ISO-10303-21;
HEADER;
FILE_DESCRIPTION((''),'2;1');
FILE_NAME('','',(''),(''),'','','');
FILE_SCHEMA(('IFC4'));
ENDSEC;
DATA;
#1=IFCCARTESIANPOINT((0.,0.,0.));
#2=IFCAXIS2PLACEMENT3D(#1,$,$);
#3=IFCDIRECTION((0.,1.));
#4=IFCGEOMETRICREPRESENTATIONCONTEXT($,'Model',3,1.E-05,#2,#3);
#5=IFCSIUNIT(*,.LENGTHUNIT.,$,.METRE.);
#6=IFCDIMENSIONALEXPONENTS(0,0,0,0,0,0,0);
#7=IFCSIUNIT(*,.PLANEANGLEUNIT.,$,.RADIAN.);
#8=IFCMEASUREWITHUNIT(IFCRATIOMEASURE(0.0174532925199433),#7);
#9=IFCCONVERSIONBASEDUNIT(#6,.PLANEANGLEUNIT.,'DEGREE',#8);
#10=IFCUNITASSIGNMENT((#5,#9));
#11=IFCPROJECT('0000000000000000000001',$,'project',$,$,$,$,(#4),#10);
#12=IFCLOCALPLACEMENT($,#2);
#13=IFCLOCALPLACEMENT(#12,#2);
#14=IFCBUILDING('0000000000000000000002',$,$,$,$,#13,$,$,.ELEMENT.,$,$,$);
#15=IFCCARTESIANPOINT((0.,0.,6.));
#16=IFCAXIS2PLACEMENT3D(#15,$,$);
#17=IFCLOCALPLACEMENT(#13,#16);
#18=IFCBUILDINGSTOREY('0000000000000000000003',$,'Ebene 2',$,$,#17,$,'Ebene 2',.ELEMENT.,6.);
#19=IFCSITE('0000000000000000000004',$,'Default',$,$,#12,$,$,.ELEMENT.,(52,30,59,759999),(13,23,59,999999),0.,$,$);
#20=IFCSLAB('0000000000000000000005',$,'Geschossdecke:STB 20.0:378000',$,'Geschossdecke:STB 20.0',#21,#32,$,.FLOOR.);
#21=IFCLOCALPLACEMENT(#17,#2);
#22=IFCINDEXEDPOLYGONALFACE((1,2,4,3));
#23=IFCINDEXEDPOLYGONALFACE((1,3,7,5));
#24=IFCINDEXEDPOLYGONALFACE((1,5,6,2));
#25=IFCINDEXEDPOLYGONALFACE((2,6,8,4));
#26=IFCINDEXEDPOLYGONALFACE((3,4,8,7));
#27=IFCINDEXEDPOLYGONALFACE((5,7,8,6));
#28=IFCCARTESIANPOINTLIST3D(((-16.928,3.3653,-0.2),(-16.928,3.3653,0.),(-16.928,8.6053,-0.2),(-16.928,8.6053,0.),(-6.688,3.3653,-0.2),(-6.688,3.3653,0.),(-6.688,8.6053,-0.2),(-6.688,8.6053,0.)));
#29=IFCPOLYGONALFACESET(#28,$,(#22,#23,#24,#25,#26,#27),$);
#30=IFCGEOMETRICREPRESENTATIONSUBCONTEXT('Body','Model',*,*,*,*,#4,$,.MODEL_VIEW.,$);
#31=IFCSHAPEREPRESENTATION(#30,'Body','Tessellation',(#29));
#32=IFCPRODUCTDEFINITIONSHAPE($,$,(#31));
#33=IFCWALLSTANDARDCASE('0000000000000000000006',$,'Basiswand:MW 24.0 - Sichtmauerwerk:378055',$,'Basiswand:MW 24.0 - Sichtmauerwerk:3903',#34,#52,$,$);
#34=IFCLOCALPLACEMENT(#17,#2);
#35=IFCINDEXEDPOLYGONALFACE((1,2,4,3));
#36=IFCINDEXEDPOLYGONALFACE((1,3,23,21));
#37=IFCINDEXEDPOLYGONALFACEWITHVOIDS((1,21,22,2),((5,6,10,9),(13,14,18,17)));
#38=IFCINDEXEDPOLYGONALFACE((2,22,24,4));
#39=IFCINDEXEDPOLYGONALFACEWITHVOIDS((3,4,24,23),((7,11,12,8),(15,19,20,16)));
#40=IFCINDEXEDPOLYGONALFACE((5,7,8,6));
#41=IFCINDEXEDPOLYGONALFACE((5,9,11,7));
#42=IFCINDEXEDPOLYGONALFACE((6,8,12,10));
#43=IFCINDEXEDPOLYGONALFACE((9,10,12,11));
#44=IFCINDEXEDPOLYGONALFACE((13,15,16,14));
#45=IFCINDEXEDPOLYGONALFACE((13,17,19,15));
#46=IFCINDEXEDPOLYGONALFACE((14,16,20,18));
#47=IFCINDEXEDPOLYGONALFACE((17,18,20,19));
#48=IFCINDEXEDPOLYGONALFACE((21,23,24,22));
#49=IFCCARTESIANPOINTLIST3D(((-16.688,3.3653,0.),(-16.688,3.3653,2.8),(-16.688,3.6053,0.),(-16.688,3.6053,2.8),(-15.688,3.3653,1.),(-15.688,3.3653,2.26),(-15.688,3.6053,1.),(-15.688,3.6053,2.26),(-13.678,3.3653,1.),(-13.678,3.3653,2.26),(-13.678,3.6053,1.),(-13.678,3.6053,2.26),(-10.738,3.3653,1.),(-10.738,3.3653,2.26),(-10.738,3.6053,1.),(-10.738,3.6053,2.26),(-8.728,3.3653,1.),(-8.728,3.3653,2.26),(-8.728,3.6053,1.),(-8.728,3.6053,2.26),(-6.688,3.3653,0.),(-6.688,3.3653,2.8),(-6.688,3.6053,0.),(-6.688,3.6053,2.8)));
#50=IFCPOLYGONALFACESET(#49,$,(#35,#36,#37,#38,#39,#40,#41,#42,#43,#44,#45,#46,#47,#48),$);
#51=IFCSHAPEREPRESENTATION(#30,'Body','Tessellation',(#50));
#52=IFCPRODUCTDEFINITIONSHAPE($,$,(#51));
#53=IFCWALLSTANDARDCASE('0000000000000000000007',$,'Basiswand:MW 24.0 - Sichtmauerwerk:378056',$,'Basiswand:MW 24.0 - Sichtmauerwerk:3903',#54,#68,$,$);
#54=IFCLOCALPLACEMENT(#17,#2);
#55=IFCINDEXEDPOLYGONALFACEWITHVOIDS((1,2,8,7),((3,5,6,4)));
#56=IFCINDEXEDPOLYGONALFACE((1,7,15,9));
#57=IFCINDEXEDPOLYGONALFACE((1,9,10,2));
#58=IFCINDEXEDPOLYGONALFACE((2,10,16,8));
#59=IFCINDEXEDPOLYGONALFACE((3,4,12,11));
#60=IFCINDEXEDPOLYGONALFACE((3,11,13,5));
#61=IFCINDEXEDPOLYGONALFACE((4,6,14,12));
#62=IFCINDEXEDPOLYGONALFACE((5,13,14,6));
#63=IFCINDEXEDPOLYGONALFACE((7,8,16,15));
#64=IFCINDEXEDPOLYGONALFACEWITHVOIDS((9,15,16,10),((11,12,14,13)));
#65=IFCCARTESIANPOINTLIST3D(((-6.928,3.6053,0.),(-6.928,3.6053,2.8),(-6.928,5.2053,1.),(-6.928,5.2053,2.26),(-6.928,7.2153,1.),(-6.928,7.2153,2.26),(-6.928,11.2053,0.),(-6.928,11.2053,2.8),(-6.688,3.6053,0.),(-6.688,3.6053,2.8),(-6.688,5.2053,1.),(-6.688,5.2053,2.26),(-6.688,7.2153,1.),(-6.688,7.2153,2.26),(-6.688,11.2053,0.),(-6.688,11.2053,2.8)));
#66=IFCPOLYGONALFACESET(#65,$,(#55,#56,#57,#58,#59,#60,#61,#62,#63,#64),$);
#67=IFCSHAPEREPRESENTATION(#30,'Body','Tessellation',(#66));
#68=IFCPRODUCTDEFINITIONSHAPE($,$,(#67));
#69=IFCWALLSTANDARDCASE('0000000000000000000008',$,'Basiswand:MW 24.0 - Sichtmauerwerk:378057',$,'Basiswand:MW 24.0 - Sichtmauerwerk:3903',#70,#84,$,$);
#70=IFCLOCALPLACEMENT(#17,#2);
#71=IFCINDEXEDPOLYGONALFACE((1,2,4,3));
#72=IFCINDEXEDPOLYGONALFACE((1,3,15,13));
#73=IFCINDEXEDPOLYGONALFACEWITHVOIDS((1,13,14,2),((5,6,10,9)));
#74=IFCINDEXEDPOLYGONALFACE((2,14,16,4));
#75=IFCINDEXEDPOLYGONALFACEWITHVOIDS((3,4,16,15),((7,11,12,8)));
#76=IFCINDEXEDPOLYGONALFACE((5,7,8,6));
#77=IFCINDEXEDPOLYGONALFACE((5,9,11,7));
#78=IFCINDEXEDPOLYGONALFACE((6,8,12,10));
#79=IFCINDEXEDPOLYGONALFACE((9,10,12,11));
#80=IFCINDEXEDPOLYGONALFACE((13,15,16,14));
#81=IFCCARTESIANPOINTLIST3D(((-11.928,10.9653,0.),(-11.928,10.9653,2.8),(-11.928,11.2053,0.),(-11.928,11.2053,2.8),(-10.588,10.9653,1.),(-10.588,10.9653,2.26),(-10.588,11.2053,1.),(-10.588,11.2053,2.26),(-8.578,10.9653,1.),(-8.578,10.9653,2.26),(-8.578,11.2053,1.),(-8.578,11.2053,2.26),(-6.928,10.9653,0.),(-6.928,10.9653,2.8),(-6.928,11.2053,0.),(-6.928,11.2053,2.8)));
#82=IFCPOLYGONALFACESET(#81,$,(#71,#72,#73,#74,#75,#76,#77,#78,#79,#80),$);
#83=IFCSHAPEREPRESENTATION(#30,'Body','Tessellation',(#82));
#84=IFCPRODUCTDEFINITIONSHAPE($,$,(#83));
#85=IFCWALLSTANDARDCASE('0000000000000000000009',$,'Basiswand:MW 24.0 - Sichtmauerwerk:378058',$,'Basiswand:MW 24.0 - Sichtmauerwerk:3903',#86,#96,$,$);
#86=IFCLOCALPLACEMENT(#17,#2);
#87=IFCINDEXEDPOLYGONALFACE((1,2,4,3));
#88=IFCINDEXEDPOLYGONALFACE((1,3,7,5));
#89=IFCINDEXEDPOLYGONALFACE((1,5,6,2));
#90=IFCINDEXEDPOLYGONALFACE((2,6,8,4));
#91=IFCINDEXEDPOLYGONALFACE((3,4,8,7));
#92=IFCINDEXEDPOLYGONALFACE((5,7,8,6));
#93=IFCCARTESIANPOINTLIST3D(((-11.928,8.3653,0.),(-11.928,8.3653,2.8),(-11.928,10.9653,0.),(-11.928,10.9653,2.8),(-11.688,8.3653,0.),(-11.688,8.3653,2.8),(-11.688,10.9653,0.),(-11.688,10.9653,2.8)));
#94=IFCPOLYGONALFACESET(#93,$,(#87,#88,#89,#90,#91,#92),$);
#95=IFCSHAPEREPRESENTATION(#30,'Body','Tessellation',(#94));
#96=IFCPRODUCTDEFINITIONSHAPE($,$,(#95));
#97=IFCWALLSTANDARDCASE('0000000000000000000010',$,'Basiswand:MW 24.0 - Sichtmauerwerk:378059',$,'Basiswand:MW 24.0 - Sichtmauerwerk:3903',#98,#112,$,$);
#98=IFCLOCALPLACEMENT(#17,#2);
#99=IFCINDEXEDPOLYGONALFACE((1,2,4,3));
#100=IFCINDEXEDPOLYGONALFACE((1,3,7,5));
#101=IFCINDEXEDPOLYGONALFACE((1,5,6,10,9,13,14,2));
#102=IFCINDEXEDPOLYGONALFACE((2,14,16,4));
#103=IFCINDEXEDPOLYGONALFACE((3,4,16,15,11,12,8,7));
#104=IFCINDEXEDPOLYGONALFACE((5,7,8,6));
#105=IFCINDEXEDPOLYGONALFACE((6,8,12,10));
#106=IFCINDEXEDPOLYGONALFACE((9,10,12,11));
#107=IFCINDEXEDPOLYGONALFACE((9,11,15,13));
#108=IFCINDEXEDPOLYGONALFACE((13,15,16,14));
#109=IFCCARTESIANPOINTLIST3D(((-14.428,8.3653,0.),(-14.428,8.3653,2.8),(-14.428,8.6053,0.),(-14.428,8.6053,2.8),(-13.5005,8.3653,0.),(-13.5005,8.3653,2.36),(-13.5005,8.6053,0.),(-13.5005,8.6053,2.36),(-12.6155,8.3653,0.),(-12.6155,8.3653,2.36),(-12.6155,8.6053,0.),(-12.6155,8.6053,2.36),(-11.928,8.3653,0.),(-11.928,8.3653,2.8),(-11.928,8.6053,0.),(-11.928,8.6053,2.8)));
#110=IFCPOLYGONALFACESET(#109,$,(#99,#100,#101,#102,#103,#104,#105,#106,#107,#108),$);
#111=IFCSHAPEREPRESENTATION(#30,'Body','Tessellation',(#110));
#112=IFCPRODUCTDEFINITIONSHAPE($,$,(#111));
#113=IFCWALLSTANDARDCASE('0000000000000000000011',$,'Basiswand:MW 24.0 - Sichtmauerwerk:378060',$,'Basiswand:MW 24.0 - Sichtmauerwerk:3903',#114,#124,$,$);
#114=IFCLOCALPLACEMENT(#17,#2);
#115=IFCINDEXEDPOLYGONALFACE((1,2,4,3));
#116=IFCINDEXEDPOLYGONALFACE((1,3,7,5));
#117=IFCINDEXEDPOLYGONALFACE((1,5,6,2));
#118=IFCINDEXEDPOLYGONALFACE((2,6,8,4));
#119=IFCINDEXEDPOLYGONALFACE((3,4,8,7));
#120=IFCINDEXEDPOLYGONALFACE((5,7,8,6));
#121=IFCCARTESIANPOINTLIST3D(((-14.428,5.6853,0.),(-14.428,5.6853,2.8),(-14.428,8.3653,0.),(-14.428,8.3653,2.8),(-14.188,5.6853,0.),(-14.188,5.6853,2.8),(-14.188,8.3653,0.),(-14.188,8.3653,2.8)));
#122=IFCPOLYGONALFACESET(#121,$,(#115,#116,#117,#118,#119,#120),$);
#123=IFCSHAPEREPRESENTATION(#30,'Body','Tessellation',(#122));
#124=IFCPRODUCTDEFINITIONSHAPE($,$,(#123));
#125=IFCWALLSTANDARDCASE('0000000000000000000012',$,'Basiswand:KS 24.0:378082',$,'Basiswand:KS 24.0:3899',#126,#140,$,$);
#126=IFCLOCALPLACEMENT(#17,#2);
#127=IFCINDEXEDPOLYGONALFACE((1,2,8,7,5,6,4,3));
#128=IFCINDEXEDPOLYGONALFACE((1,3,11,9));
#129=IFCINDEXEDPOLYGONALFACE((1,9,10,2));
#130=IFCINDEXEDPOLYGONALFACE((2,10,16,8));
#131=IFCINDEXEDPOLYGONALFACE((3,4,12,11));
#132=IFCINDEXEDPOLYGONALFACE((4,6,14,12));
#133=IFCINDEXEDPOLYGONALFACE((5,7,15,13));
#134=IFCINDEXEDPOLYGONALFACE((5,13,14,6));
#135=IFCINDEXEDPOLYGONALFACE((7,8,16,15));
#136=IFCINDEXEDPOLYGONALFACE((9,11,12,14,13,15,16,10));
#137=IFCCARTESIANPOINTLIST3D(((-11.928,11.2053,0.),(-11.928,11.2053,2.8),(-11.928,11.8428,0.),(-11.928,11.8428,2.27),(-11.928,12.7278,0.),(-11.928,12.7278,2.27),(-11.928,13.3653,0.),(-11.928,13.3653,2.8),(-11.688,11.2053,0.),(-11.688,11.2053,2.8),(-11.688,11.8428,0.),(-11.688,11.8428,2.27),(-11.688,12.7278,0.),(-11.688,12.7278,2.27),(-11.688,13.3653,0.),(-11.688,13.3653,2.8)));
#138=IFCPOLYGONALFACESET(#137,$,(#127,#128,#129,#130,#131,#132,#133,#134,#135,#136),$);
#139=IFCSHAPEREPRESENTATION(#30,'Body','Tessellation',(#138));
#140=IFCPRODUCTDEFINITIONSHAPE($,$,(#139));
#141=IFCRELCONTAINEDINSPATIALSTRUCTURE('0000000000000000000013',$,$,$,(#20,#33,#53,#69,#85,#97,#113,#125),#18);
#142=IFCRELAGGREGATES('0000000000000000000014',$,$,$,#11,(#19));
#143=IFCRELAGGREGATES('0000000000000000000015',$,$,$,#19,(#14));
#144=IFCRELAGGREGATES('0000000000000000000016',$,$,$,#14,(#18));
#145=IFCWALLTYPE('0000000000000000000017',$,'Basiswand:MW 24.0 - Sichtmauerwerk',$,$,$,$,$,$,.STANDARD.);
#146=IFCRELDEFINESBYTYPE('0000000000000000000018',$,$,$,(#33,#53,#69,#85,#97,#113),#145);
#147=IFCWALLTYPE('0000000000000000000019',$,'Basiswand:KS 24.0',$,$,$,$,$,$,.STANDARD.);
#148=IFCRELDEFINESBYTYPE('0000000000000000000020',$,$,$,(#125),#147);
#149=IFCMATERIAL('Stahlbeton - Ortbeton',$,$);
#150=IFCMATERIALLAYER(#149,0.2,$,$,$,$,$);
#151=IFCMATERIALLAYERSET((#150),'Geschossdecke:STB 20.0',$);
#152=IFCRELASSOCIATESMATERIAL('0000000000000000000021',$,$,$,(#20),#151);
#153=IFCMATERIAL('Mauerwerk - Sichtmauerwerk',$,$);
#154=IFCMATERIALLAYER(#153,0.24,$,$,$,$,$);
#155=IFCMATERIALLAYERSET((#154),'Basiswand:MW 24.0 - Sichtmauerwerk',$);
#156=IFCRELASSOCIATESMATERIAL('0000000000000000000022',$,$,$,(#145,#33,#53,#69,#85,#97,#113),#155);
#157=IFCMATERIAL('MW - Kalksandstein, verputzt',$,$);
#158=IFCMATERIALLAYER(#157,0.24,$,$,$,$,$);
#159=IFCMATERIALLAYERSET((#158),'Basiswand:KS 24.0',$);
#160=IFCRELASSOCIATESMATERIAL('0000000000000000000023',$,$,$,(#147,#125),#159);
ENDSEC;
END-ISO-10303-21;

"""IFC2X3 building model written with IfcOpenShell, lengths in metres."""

from ifc_helpers import new_model, entity, si_unit, converted_unit, direction, frame, frame_2d, origin, origin_2d_with_axis, place, context, subcontext, project, spatial, polyline, rectangle, extrude, clip, bounded_halfspace, material, layer, layer_set, layer_usage, type_object, element, save


model = new_model("IFC2X3")

# Units and contexts
model_context = context("Model", 3, precision=1e-05, world=origin(), true_north=direction((0.0, 1.0)))
body_context = subcontext(model_context, "Body", "Model", "MODEL_VIEW")
ifc_project = project(units=[si_unit("LENGTHUNIT", "METRE"), converted_unit("PLANEANGLEUNIT", "DEGREE", entity("IfcRatioMeasure", 0.0174532925199433), si_unit("PLANEANGLEUNIT", "RADIAN"), dimensions=[0, 0, 0, 0, 0, 0, 0])], contexts=[model_context])

# Site, building, storey
site_placement = place(None, origin())
site = spatial("IfcSite", under=ifc_project, at=site_placement, Name="Default", CompositionType="ELEMENT", RefLatitude=(52, 30, 59, 759999), RefLongitude=(13, 23, 59, 999999), RefElevation=0.0)
building_placement = place(site_placement, origin())
building = spatial("IfcBuilding", under=site, at=building_placement, CompositionType="ELEMENT")
storey_placement = place(building_placement, frame((0.0, 0.0, 6.0)))
storey = spatial("IfcBuildingStorey", under=building, at=storey_placement, Name="Ebene 2", LongName="Ebene 2", CompositionType="ELEMENT", Elevation=6.0)

# Shared definitions
ifc_material_1 = material(Name="Stahlbeton - Ortbeton")

# Slab
ifc_layer_1 = layer(ifc_material_1, 0.2)
ifc_layer_set_1 = layer_set([ifc_layer_1], Name="Geschossdecke:STB 20.0")
ifc_layer_usage_1 = layer_usage(ifc_layer_set_1, "AXIS3", "POSITIVE", 0.0)
slab_1_placement = place(storey_placement, origin())
element("IfcSlab", 1, at=slab_1_placement, inside=storey, material=ifc_layer_usage_1, Name="Geschossdecke:STB 20.0:378000", ObjectType="Geschossdecke:STB 20.0", PredefinedType="FLOOR", context=body_context, shape_type="SweptSolid", body=[
    extrude(rectangle(XDim=5.24, YDim=10.24, at=origin_2d_with_axis()), frame((-11.808, 5.9853, 0.0), z_axis=(0.0, 0.0, -1.0), x_axis=(0.0, 1.0, 0.0)), (0.0, 0.0, 1.0), 0.2),
])

# Wall, openings
ifc_material_2 = material(Name="Mauerwerk - Sichtmauerwerk")
ifc_layer_2 = layer(ifc_material_2, 0.24)
ifc_layer_set_2 = layer_set([ifc_layer_2], Name="Basiswand:MW 24.0 - Sichtmauerwerk")
ifc_layer_usage_2 = layer_usage(ifc_layer_set_2, "AXIS2", "NEGATIVE", 0.12)
wall_type_1 = type_object("IfcWallType", Name="Basiswand:MW 24.0 - Sichtmauerwerk", PredefinedType="STANDARD", material=ifc_layer_set_2)
wall_1_placement = place(storey_placement, frame((-16.688, 3.4853, 0.0)))
wall_1 = element("IfcWallStandardCase", 2, at=wall_1_placement, inside=storey, type_object=wall_type_1, material=ifc_layer_usage_2, Name="Basiswand:MW 24.0 - Sichtmauerwerk:378055", ObjectType="Basiswand:MW 24.0 - Sichtmauerwerk:3903", context=body_context, shape_type="Clipping", body=[
    clip(extrude(rectangle(XDim=10.0, YDim=0.24, at=frame_2d((5.0, 0.0), x_axis=(-1.0, 0.0))), origin(), (0.0, 0.0, 1.0), 2.8), bounded_halfspace(frame((0.0, -0.12, 2.8), z_axis=(0.0, 0.0, -1.0), x_axis=(-1.0, 0.0, 0.0)), True, frame((0.0, -0.12, 2.8)), polyline([(0.0, 0.0), (10.0, 0.0), (10.0, 0.24), (9.76, 0.24), (0.0, 0.24), (0.0, 0.0)]))),
])
opening_1_placement = place(wall_1_placement, frame((1.0, -0.12, 1.0)))
element("IfcOpeningElement", 3, at=opening_1_placement, cuts=wall_1, ObjectType="Opening", context=body_context, shape_type="SweptSolid", body=[
    extrude(rectangle(XDim=1.26, YDim=2.01, at=frame_2d((0.63, 1.005), x_axis=(1.0, 0.0))), frame((0.0, 0.0, 0.0), z_axis=(0.0, 1.0, 0.0), x_axis=(0.0, 0.0, 1.0)), (0.0, 0.0, 1.0), 0.24),
])
opening_2_placement = place(wall_1_placement, frame((5.95, -0.12, 1.0)))
element("IfcOpeningElement", 4, at=opening_2_placement, cuts=wall_1, ObjectType="Opening", context=body_context, shape_type="SweptSolid", body=[
    extrude(rectangle(XDim=1.26, YDim=2.01, at=frame_2d((0.63, 1.005), x_axis=(1.0, 0.0))), frame((0.0, 0.0, 0.0), z_axis=(0.0, 1.0, 0.0), x_axis=(0.0, 0.0, 1.0)), (0.0, 0.0, 1.0), 0.24),
])

# Walls, openings
ifc_layer_usage_3 = layer_usage(ifc_layer_set_2, "AXIS2", "NEGATIVE", 0.12)
wall_2_placement = place(storey_placement, frame((-6.808, 3.6053, 0.0), z_axis=(0.0, 0.0, 1.0), x_axis=(0.0, 1.0, 0.0)))
wall_2 = element("IfcWallStandardCase", 5, at=wall_2_placement, inside=storey, type_object=wall_type_1, material=ifc_layer_usage_3, Name="Basiswand:MW 24.0 - Sichtmauerwerk:378056", ObjectType="Basiswand:MW 24.0 - Sichtmauerwerk:3903", context=body_context, shape_type="Clipping", body=[
    clip(clip(extrude(rectangle(XDim=7.6, YDim=0.24, at=frame_2d((3.8, 0.0), x_axis=(-1.0, 0.0))), origin(), (0.0, 0.0, 1.0), 2.8), bounded_halfspace(frame((0.0, -0.12, 2.8), z_axis=(0.0, 0.0, -1.0), x_axis=(0.0, 1.0, 0.0)), True, frame((0.0, -0.12, 2.8)), polyline([(0.0, 0.0), (5.0, 0.0), (5.0, 0.24), (0.0, 0.24), (0.0, 0.0)]))), bounded_halfspace(frame((5.005, -0.12, 2.8), z_axis=(0.0, 0.0, -1.0), x_axis=(1.0, 0.0, 0.0)), True, frame((5.005, -0.12, 2.8)), polyline([(0.0, 0.0), (2.595, 0.0), (2.595, 0.24), (2.355, 0.24), (0.0, 0.24), (0.0, 0.0)]))),
])
opening_3_placement = place(wall_2_placement, frame((1.6, -0.12, 1.0)))
element("IfcOpeningElement", 6, at=opening_3_placement, cuts=wall_2, ObjectType="Opening", context=body_context, shape_type="SweptSolid", body=[
    extrude(rectangle(XDim=1.26, YDim=2.01, at=frame_2d((0.63, 1.005), x_axis=(1.0, 0.0))), frame((0.0, 0.0, 0.0), z_axis=(0.0, 1.0, 0.0), x_axis=(0.0, 0.0, 1.0)), (0.0, 0.0, 1.0), 0.24),
])
ifc_layer_usage_4 = layer_usage(ifc_layer_set_2, "AXIS2", "NEGATIVE", 0.12)
wall_3_placement = place(storey_placement, frame((-6.928, 11.0853, 0.0), z_axis=(0.0, 0.0, 1.0), x_axis=(-1.0, 0.0, 0.0)))
wall_3 = element("IfcWallStandardCase", 7, at=wall_3_placement, inside=storey, type_object=wall_type_1, material=ifc_layer_usage_4, Name="Basiswand:MW 24.0 - Sichtmauerwerk:378057", ObjectType="Basiswand:MW 24.0 - Sichtmauerwerk:3903", context=body_context, shape_type="Clipping", body=[
    clip(extrude(rectangle(XDim=5.0, YDim=0.24, at=frame_2d((2.5, 0.0), x_axis=(-1.0, 0.0))), origin(), (0.0, 0.0, 1.0), 2.8), bounded_halfspace(frame((0.0, -0.12, 2.8), z_axis=(0.0, 0.0, -1.0), x_axis=(0.0, -1.0, 0.0)), True, frame((0.0, -0.12, 2.8)), polyline([(0.0, 0.0), (4.76, 0.0), (5.0, 0.0), (5.0, 0.24), (4.76, 0.24), (0.0, 0.24), (0.0, 0.0)]))),
])
opening_4_placement = place(wall_3_placement, frame((1.65, -0.12, 1.0)))
element("IfcOpeningElement", 8, at=opening_4_placement, cuts=wall_3, ObjectType="Opening", context=body_context, shape_type="SweptSolid", body=[
    extrude(rectangle(XDim=1.26, YDim=2.01, at=frame_2d((0.63, 1.005), x_axis=(1.0, 0.0))), frame((0.0, 0.0, 0.0), z_axis=(0.0, 1.0, 0.0), x_axis=(0.0, 0.0, 1.0)), (0.0, 0.0, 1.0), 0.24),
])

# Wall
ifc_layer_usage_5 = layer_usage(ifc_layer_set_2, "AXIS2", "NEGATIVE", 0.12)
wall_4_placement = place(storey_placement, frame((-11.808, 10.9653, 0.0), z_axis=(0.0, 0.0, 1.0), x_axis=(0.0, -1.0, 0.0)))
element("IfcWallStandardCase", 9, at=wall_4_placement, inside=storey, type_object=wall_type_1, material=ifc_layer_usage_5, Name="Basiswand:MW 24.0 - Sichtmauerwerk:378058", ObjectType="Basiswand:MW 24.0 - Sichtmauerwerk:3903", context=body_context, shape_type="Clipping", body=[
    clip(clip(extrude(rectangle(XDim=2.6, YDim=0.24, at=frame_2d((1.3, 0.0), x_axis=(-1.0, 0.0))), origin(), (0.0, 0.0, 1.0), 2.8), bounded_halfspace(frame((2.36, -0.12, 2.8), z_axis=(0.0, 0.0, -1.0), x_axis=(0.0, -1.0, 0.0)), True, frame((2.36, -0.12, 2.8)), polyline([(0.0, 0.0), (0.24, 0.0), (0.24, 0.24), (0.0, 0.24), (0.0, 0.0)]))), bounded_halfspace(frame((0.0, -0.12, 2.8), z_axis=(0.0, 0.0, -1.0), x_axis=(-1.0, 0.0, 0.0)), True, frame((0.0, -0.12, 2.8)), polyline([(0.0, 0.0), (2.355, 0.0), (2.355, 0.24), (0.0, 0.24), (0.0, 0.0)]))),
])

# Wall, opening
ifc_layer_usage_6 = layer_usage(ifc_layer_set_2, "AXIS2", "NEGATIVE", 0.12)
wall_5_placement = place(storey_placement, frame((-11.928, 8.4853, 0.0), z_axis=(0.0, 0.0, 1.0), x_axis=(-1.0, 0.0, 0.0)))
wall_5 = element("IfcWallStandardCase", 10, at=wall_5_placement, inside=storey, type_object=wall_type_1, material=ifc_layer_usage_6, Name="Basiswand:MW 24.0 - Sichtmauerwerk:378059", ObjectType="Basiswand:MW 24.0 - Sichtmauerwerk:3903", context=body_context, shape_type="Clipping", body=[
    clip(extrude(rectangle(XDim=2.5, YDim=0.24, at=frame_2d((1.25, 0.0), x_axis=(-1.0, 0.0))), origin(), (0.0, 0.0, 1.0), 2.8), bounded_halfspace(frame((0.0, -0.12, 2.8), z_axis=(0.0, 0.0, -1.0), x_axis=(1.0, 0.0, 0.0)), True, frame((0.0, -0.12, 2.8)), polyline([(0.0, 0.0), (2.5, 0.0), (2.5, 0.24), (2.26, 0.24), (0.0, 0.24), (0.0, 0.0)]))),
])
opening_5_placement = place(wall_5_placement, frame((1.5725, 0.12, 0.0)))
element("IfcOpeningElement", 11, at=opening_5_placement, cuts=wall_5, ObjectType="Opening", context=body_context, shape_type="SweptSolid", body=[
    extrude(rectangle(XDim=2.36, YDim=0.885, at=frame_2d((1.18, 0.4425), x_axis=(1.0, 0.0))), frame((0.0, 0.0, 0.0), z_axis=(0.0, -1.0, 0.0), x_axis=(0.0, 0.0, 1.0)), (0.0, 0.0, 1.0), 0.24),
])

# Wall
ifc_layer_usage_7 = layer_usage(ifc_layer_set_2, "AXIS2", "NEGATIVE", 0.12)
wall_6_placement = place(storey_placement, frame((-14.308, 8.3653, 0.0), z_axis=(0.0, 0.0, 1.0), x_axis=(0.0, -1.0, 0.0)))
element("IfcWallStandardCase", 12, at=wall_6_placement, inside=storey, type_object=wall_type_1, material=ifc_layer_usage_7, Name="Basiswand:MW 24.0 - Sichtmauerwerk:378060", ObjectType="Basiswand:MW 24.0 - Sichtmauerwerk:3903", context=body_context, shape_type="Clipping", body=[
    clip(extrude(rectangle(XDim=2.68, YDim=0.24, at=frame_2d((1.34, 0.0), x_axis=(-1.0, 0.0))), origin(), (0.0, 0.0, 1.0), 2.8), bounded_halfspace(frame((0.0, -0.12, 2.8), z_axis=(0.0, 0.0, -1.0), x_axis=(0.0, -1.0, 0.0)), True, frame((0.0, -0.12, 2.8)), polyline([(0.0, 0.0), (2.68, 0.0), (2.68, 0.24), (0.0, 0.24), (0.0, 0.0)]))),
])

# Wall, opening
ifc_material_3 = material(Name="MW - Kalksandstein, verputzt")
ifc_layer_3 = layer(ifc_material_3, 0.24)
ifc_layer_set_3 = layer_set([ifc_layer_3], Name="Basiswand:KS 24.0")
ifc_layer_usage_8 = layer_usage(ifc_layer_set_3, "AXIS2", "NEGATIVE", 0.12)
wall_type_2 = type_object("IfcWallType", Name="Basiswand:KS 24.0", PredefinedType="STANDARD", material=ifc_layer_set_3)
wall_7_placement = place(storey_placement, frame((-11.808, 13.3653, 0.0), z_axis=(0.0, 0.0, 1.0), x_axis=(0.0, -1.0, 0.0)))
wall_7 = element("IfcWallStandardCase", 13, at=wall_7_placement, inside=storey, type_object=wall_type_2, material=ifc_layer_usage_8, Name="Basiswand:KS 24.0:378082", ObjectType="Basiswand:KS 24.0:3899", context=body_context, shape_type="Clipping", body=[
    clip(extrude(rectangle(XDim=2.16, YDim=0.24, at=frame_2d((1.08, 0.0), x_axis=(-1.0, 0.0))), origin(), (0.0, 0.0, 1.0), 2.8), bounded_halfspace(frame((0.0, -0.12, 2.8), z_axis=(0.0, 0.0, -1.0), x_axis=(-1.0, 0.0, 0.0)), True, frame((0.0, -0.12, 2.8)), polyline([(0.0, 0.0), (2.16, 0.0), (2.16, 0.24), (0.0, 0.24), (0.0, 0.0)]))),
])
opening_6_placement = place(wall_7_placement, frame((1.5225, 0.12, 0.0)))
element("IfcOpeningElement", 14, at=opening_6_placement, cuts=wall_7, ObjectType="Opening", context=body_context, shape_type="SweptSolid", body=[
    extrude(rectangle(XDim=2.27, YDim=0.885, at=frame_2d((1.135, 0.4425), x_axis=(1.0, 0.0))), frame((0.0, 0.0, 0.0), z_axis=(0.0, -1.0, 0.0), x_axis=(0.0, 0.0, 1.0)), (0.0, 0.0, 1.0), 0.24),
])

save(model, "model.ifc")
